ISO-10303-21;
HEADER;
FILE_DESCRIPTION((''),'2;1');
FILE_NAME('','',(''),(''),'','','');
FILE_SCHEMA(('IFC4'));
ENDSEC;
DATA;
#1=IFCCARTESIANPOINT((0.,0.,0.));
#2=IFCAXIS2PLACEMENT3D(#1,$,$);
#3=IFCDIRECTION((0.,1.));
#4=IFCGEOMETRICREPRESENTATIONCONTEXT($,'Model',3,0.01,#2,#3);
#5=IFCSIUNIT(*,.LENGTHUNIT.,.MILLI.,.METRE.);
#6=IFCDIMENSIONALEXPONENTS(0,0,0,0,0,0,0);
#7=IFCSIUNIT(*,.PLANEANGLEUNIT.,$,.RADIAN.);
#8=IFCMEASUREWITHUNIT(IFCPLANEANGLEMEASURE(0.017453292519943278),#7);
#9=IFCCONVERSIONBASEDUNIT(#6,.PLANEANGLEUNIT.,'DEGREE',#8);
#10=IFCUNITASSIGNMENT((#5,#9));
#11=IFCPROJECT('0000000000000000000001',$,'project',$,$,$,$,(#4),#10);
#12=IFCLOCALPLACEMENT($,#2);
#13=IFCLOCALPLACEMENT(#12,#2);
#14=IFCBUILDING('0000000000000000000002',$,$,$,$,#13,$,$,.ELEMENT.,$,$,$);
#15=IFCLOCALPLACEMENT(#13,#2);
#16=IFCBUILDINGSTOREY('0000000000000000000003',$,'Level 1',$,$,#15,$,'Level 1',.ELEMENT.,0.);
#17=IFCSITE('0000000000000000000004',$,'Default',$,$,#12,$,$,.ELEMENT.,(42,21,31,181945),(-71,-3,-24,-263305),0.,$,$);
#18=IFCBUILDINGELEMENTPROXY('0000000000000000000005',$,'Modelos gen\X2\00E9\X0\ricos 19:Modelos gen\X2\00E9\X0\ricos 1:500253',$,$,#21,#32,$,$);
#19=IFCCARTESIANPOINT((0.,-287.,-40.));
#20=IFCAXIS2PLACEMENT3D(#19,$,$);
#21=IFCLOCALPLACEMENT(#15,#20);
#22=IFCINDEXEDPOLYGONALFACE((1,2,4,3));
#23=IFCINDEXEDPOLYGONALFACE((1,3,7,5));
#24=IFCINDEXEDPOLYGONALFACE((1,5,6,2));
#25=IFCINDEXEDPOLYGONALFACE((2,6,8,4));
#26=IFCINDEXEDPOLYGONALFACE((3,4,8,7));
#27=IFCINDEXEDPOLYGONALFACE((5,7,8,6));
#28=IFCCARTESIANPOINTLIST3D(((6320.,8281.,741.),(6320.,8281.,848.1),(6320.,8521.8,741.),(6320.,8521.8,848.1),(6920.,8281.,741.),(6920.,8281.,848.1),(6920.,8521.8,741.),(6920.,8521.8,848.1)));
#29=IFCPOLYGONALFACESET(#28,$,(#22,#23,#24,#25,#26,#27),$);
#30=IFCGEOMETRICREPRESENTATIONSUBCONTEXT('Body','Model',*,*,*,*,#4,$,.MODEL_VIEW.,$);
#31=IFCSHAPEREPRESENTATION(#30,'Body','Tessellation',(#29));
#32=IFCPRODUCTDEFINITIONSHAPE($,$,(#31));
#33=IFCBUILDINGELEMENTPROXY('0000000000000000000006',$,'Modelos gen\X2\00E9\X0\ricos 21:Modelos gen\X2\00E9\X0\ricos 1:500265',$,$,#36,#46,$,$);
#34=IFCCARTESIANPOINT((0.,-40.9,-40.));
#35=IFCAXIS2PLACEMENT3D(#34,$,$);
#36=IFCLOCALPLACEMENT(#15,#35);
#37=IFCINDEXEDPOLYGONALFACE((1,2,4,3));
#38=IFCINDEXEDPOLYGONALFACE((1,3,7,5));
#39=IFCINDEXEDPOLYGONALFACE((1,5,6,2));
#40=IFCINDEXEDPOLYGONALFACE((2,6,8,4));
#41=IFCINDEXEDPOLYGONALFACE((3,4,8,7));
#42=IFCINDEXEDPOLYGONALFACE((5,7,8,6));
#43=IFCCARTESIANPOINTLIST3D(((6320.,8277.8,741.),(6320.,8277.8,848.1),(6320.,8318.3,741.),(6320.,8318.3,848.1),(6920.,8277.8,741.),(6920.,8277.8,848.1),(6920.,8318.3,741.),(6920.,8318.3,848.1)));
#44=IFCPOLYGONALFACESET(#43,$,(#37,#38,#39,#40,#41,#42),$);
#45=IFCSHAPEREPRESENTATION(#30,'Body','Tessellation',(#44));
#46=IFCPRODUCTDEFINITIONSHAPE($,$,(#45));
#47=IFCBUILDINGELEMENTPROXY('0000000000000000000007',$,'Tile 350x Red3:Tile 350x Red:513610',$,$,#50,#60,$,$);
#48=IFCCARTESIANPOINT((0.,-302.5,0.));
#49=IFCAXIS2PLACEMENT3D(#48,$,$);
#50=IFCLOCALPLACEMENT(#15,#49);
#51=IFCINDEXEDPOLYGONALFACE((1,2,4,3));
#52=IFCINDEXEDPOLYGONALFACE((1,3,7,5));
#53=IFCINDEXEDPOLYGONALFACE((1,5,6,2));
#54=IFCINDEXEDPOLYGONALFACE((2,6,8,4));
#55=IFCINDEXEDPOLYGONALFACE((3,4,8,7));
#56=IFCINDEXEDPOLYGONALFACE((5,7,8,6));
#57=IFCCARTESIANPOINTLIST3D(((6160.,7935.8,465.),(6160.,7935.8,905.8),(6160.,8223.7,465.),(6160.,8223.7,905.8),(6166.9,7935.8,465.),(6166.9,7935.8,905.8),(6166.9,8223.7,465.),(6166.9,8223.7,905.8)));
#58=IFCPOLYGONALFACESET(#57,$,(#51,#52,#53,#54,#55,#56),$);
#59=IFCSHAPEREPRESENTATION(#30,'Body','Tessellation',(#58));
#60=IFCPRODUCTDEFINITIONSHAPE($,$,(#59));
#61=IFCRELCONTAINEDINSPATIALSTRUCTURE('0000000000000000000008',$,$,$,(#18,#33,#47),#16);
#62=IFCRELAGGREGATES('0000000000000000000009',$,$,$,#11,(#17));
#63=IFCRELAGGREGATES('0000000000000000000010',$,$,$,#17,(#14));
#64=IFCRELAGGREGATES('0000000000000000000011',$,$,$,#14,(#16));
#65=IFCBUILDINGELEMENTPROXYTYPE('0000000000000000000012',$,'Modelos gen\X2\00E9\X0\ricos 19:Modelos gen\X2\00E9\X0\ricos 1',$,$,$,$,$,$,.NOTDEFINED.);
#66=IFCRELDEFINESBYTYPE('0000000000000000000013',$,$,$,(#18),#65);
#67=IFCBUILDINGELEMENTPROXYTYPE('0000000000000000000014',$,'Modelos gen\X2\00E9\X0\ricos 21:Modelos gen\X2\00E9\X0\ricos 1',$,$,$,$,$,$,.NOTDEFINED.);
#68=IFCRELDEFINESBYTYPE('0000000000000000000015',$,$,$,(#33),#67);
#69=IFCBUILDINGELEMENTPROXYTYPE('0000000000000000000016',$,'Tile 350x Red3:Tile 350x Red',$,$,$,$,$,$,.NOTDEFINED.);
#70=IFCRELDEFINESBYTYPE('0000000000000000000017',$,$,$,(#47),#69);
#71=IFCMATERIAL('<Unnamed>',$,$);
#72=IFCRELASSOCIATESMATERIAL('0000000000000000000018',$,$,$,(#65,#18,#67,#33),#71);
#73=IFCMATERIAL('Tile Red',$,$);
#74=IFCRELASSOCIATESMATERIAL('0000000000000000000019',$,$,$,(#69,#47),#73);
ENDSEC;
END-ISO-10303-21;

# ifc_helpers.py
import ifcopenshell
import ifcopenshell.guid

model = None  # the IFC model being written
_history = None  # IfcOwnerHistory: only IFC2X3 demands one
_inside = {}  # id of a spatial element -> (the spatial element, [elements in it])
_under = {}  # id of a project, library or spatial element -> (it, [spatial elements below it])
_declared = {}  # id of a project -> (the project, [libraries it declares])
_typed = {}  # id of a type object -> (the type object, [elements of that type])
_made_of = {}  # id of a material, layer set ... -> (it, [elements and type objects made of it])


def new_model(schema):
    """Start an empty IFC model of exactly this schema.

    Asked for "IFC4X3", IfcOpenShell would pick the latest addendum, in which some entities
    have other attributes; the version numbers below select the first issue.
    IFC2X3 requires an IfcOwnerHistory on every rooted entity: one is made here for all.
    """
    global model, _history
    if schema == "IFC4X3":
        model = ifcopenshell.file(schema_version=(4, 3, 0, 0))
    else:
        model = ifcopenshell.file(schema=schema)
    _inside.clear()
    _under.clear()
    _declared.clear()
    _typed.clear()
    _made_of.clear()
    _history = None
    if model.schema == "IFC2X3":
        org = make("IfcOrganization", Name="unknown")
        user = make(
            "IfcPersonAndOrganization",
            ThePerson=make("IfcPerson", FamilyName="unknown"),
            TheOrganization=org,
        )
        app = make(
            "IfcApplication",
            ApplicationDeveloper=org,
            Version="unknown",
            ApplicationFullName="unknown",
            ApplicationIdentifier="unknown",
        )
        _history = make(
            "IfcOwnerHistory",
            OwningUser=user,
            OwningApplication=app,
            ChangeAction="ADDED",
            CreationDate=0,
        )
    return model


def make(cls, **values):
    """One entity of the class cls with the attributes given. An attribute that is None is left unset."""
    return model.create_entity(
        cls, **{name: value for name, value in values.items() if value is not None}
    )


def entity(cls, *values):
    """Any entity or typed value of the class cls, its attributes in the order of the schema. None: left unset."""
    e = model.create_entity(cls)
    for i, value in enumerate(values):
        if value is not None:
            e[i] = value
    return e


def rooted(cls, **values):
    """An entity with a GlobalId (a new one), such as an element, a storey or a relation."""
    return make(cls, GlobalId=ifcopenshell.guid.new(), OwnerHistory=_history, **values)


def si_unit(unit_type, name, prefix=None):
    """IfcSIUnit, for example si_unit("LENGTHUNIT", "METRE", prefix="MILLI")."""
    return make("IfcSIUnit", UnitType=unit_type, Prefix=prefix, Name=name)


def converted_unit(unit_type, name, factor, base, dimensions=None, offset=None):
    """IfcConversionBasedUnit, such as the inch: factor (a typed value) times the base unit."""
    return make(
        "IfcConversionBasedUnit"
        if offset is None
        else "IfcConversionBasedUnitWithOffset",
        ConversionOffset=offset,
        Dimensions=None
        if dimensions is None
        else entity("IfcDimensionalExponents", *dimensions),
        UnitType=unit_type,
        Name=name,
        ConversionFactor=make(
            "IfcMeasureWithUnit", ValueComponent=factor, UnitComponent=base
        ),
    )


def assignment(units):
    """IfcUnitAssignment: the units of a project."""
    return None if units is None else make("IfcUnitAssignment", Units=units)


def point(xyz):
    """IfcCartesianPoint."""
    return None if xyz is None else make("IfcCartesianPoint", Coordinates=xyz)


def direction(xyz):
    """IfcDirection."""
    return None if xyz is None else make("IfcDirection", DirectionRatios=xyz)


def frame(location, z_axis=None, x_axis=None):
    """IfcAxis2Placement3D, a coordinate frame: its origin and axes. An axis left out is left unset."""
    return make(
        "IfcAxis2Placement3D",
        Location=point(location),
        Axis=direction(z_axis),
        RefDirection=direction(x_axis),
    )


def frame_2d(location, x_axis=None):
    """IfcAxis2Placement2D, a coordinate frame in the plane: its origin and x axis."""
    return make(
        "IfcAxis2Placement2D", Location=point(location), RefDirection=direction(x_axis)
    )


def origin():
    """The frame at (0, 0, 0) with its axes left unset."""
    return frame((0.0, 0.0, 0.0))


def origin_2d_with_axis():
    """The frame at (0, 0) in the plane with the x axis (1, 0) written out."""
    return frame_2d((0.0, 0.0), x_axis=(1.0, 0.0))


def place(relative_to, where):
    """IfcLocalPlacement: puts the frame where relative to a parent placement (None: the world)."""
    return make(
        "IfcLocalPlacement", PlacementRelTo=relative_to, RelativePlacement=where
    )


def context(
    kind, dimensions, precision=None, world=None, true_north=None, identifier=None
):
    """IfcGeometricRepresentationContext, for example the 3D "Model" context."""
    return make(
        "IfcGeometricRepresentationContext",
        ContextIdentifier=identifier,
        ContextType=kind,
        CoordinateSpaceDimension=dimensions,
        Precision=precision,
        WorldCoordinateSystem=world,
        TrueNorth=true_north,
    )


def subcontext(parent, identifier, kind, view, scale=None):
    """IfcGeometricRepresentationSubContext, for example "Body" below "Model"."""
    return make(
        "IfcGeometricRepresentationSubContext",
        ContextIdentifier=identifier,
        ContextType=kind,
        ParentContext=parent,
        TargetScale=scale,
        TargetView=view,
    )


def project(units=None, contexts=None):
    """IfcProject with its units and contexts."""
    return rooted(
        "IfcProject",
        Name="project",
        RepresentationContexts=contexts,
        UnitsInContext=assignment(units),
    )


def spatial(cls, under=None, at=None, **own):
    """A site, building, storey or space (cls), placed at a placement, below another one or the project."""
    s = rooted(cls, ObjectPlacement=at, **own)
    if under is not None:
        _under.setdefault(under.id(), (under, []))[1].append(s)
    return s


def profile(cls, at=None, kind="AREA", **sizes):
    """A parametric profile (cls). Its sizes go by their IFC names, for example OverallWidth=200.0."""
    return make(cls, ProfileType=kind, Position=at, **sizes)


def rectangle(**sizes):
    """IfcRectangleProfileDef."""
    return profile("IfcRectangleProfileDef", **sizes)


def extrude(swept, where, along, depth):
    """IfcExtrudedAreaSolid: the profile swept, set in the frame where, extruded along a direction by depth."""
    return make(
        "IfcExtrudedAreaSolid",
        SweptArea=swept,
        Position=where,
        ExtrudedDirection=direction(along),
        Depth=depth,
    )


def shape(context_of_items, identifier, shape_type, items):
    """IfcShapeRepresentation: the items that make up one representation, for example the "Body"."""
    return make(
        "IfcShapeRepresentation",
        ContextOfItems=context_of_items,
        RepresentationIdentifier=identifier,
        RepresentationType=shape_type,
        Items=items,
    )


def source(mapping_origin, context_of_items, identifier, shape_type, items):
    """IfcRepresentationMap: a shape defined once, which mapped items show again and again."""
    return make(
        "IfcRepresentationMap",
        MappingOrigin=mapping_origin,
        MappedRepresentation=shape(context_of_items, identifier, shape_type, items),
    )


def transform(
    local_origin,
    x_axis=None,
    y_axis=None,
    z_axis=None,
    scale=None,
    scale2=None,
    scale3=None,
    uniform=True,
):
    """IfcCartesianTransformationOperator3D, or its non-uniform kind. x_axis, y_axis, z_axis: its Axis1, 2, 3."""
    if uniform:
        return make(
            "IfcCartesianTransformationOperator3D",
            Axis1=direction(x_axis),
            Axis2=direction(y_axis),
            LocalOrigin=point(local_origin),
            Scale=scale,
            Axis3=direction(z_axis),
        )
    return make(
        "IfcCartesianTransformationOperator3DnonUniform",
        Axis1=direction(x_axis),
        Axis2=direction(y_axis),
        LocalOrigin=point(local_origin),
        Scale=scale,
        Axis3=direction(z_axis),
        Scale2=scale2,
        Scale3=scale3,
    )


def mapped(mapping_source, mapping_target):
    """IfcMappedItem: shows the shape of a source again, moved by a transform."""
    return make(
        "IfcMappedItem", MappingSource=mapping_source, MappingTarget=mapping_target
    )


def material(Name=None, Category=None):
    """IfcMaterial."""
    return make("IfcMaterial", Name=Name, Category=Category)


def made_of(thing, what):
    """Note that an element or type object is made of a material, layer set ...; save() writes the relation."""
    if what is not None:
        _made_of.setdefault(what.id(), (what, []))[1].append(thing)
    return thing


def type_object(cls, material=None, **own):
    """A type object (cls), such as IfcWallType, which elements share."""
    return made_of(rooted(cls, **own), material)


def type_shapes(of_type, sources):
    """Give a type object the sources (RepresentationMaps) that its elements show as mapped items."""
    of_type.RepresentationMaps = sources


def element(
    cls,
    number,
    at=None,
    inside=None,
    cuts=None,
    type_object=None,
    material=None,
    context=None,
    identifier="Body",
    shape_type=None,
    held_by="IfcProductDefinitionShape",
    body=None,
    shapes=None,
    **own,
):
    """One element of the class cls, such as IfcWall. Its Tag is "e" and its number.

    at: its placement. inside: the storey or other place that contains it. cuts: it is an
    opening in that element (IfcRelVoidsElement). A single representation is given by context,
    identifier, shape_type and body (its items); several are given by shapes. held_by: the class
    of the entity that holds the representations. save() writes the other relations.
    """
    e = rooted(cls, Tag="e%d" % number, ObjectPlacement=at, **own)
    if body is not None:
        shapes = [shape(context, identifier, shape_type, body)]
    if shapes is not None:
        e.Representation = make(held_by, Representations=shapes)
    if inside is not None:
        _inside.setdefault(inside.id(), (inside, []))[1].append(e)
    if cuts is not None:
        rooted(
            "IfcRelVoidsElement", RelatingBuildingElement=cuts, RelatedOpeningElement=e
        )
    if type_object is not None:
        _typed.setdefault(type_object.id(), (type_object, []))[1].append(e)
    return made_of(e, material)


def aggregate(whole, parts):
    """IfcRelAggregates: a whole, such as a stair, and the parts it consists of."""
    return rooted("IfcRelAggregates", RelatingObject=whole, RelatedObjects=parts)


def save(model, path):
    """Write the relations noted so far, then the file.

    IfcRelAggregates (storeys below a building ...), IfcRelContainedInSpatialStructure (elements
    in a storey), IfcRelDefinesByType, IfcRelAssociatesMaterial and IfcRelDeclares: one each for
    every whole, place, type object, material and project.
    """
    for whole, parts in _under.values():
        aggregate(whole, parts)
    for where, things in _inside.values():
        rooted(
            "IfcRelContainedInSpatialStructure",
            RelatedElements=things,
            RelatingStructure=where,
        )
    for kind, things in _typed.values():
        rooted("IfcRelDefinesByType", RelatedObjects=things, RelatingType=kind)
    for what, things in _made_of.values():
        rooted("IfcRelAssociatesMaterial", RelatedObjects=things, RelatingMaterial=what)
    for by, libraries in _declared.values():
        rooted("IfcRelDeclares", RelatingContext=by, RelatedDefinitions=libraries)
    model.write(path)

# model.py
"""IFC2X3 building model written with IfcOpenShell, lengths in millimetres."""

from ifc_helpers import new_model, entity, si_unit, converted_unit, direction, frame, frame_2d, origin, origin_2d_with_axis, place, context, subcontext, project, spatial, rectangle, extrude, source, transform, mapped, material, type_object, type_shapes, element, save


model = new_model("IFC2X3")

# Units and contexts
model_context = context("Model", 3, precision=0.01, world=origin(), true_north=direction((0.0, 1.0)))
body_context = subcontext(model_context, "Body", "Model", "MODEL_VIEW")
ifc_project = project(units=[si_unit("LENGTHUNIT", "METRE", prefix="MILLI"), converted_unit("PLANEANGLEUNIT", "DEGREE", entity("IfcPlaneAngleMeasure", 0.017453292519943278), si_unit("PLANEANGLEUNIT", "RADIAN"), dimensions=[0, 0, 0, 0, 0, 0, 0])], contexts=[model_context])

# Site, building, storey
site_placement = place(None, origin())
site = spatial("IfcSite", under=ifc_project, at=site_placement, Name="Default", CompositionType="ELEMENT", RefLatitude=(42, 21, 31, 181945), RefLongitude=(-71, -3, -24, -263305), RefElevation=0.0)
building_placement = place(site_placement, origin())
building = spatial("IfcBuilding", under=site, at=building_placement, CompositionType="ELEMENT")
storey_placement = place(building_placement, origin())
storey = spatial("IfcBuildingStorey", under=building, at=storey_placement, Name="Level 1", LongName="Level 1", CompositionType="ELEMENT", Elevation=0.0)

# Building element proxies
ifc_material_1 = material(Name="Tile Red")
ifc_material_2 = material(Name="<Unnamed>")
building_element_proxy_type_1 = type_object("IfcBuildingElementProxyType", Name="Modelos genéricos 19:Modelos genéricos 1", PredefinedType="NOTDEFINED", material=ifc_material_2)
shared_shape_1 = source(origin(), body_context, "Body", "SweptSolid", [
    extrude(rectangle(XDim=600.0, YDim=240.9, at=origin_2d_with_axis()), frame((6620.0, 8401.4, 741.0), z_axis=(0.0, 0.0, 1.0), x_axis=(-1.0, 0.0, 0.0)), (0.0, 0.0, 1.0), 107.1),
])
type_shapes(building_element_proxy_type_1, [shared_shape_1])
proxy_1_placement = place(storey_placement, frame((0.0, -287.0, -40.0)))
element("IfcBuildingElementProxy", 1, at=proxy_1_placement, inside=storey, type_object=building_element_proxy_type_1, material=ifc_material_2, Name="Modelos genéricos 19:Modelos genéricos 1:500253", context=body_context, shape_type="MappedRepresentation", body=[
    mapped(shared_shape_1, transform((0.0, 0.0, 0.0), scale=1.0)),
])
building_element_proxy_type_2 = type_object("IfcBuildingElementProxyType", Name="Modelos genéricos 21:Modelos genéricos 1", PredefinedType="NOTDEFINED", material=ifc_material_2)
shared_shape_2 = source(origin(), body_context, "Body", "SweptSolid", [
    extrude(rectangle(XDim=600.0, YDim=40.4, at=origin_2d_with_axis()), frame((6620.0, 8298.1, 741.0), z_axis=(0.0, 0.0, 1.0), x_axis=(-1.0, 0.0, 0.0)), (0.0, 0.0, 1.0), 107.1),
])
type_shapes(building_element_proxy_type_2, [shared_shape_2])
proxy_2_placement = place(storey_placement, frame((0.0, -40.9, -40.0)))
element("IfcBuildingElementProxy", 2, at=proxy_2_placement, inside=storey, type_object=building_element_proxy_type_2, material=ifc_material_2, Name="Modelos genéricos 21:Modelos genéricos 1:500265", context=body_context, shape_type="MappedRepresentation", body=[
    mapped(shared_shape_2, transform((0.0, 0.0, 0.0), scale=1.0)),
])
building_element_proxy_type_3 = type_object("IfcBuildingElementProxyType", Name="Tile 350x Red3:Tile 350x Red", PredefinedType="NOTDEFINED", material=ifc_material_1)
shared_shape_3 = source(origin(), body_context, "Body", "SweptSolid", [
    extrude(rectangle(XDim=6.9, YDim=287.9, at=frame_2d((0.0, 0.0), x_axis=(1.0, 0.0))), frame((6163.4, 8079.7, 465.0), z_axis=(0.0, 0.0, 1.0), x_axis=(-1.0, 0.0, 0.0)), (0.0, 0.0, 1.0), 440.8),
])
type_shapes(building_element_proxy_type_3, [shared_shape_3])
proxy_3_placement = place(storey_placement, frame((0.0, -302.5, 0.0)))
element("IfcBuildingElementProxy", 3, at=proxy_3_placement, inside=storey, type_object=building_element_proxy_type_3, material=ifc_material_1, Name="Tile 350x Red3:Tile 350x Red:513610", context=body_context, shape_type="MappedRepresentation", body=[
    mapped(shared_shape_3, transform((0.0, 0.0, 0.0), scale=1.0)),
])

save(model, "model.ifc")
